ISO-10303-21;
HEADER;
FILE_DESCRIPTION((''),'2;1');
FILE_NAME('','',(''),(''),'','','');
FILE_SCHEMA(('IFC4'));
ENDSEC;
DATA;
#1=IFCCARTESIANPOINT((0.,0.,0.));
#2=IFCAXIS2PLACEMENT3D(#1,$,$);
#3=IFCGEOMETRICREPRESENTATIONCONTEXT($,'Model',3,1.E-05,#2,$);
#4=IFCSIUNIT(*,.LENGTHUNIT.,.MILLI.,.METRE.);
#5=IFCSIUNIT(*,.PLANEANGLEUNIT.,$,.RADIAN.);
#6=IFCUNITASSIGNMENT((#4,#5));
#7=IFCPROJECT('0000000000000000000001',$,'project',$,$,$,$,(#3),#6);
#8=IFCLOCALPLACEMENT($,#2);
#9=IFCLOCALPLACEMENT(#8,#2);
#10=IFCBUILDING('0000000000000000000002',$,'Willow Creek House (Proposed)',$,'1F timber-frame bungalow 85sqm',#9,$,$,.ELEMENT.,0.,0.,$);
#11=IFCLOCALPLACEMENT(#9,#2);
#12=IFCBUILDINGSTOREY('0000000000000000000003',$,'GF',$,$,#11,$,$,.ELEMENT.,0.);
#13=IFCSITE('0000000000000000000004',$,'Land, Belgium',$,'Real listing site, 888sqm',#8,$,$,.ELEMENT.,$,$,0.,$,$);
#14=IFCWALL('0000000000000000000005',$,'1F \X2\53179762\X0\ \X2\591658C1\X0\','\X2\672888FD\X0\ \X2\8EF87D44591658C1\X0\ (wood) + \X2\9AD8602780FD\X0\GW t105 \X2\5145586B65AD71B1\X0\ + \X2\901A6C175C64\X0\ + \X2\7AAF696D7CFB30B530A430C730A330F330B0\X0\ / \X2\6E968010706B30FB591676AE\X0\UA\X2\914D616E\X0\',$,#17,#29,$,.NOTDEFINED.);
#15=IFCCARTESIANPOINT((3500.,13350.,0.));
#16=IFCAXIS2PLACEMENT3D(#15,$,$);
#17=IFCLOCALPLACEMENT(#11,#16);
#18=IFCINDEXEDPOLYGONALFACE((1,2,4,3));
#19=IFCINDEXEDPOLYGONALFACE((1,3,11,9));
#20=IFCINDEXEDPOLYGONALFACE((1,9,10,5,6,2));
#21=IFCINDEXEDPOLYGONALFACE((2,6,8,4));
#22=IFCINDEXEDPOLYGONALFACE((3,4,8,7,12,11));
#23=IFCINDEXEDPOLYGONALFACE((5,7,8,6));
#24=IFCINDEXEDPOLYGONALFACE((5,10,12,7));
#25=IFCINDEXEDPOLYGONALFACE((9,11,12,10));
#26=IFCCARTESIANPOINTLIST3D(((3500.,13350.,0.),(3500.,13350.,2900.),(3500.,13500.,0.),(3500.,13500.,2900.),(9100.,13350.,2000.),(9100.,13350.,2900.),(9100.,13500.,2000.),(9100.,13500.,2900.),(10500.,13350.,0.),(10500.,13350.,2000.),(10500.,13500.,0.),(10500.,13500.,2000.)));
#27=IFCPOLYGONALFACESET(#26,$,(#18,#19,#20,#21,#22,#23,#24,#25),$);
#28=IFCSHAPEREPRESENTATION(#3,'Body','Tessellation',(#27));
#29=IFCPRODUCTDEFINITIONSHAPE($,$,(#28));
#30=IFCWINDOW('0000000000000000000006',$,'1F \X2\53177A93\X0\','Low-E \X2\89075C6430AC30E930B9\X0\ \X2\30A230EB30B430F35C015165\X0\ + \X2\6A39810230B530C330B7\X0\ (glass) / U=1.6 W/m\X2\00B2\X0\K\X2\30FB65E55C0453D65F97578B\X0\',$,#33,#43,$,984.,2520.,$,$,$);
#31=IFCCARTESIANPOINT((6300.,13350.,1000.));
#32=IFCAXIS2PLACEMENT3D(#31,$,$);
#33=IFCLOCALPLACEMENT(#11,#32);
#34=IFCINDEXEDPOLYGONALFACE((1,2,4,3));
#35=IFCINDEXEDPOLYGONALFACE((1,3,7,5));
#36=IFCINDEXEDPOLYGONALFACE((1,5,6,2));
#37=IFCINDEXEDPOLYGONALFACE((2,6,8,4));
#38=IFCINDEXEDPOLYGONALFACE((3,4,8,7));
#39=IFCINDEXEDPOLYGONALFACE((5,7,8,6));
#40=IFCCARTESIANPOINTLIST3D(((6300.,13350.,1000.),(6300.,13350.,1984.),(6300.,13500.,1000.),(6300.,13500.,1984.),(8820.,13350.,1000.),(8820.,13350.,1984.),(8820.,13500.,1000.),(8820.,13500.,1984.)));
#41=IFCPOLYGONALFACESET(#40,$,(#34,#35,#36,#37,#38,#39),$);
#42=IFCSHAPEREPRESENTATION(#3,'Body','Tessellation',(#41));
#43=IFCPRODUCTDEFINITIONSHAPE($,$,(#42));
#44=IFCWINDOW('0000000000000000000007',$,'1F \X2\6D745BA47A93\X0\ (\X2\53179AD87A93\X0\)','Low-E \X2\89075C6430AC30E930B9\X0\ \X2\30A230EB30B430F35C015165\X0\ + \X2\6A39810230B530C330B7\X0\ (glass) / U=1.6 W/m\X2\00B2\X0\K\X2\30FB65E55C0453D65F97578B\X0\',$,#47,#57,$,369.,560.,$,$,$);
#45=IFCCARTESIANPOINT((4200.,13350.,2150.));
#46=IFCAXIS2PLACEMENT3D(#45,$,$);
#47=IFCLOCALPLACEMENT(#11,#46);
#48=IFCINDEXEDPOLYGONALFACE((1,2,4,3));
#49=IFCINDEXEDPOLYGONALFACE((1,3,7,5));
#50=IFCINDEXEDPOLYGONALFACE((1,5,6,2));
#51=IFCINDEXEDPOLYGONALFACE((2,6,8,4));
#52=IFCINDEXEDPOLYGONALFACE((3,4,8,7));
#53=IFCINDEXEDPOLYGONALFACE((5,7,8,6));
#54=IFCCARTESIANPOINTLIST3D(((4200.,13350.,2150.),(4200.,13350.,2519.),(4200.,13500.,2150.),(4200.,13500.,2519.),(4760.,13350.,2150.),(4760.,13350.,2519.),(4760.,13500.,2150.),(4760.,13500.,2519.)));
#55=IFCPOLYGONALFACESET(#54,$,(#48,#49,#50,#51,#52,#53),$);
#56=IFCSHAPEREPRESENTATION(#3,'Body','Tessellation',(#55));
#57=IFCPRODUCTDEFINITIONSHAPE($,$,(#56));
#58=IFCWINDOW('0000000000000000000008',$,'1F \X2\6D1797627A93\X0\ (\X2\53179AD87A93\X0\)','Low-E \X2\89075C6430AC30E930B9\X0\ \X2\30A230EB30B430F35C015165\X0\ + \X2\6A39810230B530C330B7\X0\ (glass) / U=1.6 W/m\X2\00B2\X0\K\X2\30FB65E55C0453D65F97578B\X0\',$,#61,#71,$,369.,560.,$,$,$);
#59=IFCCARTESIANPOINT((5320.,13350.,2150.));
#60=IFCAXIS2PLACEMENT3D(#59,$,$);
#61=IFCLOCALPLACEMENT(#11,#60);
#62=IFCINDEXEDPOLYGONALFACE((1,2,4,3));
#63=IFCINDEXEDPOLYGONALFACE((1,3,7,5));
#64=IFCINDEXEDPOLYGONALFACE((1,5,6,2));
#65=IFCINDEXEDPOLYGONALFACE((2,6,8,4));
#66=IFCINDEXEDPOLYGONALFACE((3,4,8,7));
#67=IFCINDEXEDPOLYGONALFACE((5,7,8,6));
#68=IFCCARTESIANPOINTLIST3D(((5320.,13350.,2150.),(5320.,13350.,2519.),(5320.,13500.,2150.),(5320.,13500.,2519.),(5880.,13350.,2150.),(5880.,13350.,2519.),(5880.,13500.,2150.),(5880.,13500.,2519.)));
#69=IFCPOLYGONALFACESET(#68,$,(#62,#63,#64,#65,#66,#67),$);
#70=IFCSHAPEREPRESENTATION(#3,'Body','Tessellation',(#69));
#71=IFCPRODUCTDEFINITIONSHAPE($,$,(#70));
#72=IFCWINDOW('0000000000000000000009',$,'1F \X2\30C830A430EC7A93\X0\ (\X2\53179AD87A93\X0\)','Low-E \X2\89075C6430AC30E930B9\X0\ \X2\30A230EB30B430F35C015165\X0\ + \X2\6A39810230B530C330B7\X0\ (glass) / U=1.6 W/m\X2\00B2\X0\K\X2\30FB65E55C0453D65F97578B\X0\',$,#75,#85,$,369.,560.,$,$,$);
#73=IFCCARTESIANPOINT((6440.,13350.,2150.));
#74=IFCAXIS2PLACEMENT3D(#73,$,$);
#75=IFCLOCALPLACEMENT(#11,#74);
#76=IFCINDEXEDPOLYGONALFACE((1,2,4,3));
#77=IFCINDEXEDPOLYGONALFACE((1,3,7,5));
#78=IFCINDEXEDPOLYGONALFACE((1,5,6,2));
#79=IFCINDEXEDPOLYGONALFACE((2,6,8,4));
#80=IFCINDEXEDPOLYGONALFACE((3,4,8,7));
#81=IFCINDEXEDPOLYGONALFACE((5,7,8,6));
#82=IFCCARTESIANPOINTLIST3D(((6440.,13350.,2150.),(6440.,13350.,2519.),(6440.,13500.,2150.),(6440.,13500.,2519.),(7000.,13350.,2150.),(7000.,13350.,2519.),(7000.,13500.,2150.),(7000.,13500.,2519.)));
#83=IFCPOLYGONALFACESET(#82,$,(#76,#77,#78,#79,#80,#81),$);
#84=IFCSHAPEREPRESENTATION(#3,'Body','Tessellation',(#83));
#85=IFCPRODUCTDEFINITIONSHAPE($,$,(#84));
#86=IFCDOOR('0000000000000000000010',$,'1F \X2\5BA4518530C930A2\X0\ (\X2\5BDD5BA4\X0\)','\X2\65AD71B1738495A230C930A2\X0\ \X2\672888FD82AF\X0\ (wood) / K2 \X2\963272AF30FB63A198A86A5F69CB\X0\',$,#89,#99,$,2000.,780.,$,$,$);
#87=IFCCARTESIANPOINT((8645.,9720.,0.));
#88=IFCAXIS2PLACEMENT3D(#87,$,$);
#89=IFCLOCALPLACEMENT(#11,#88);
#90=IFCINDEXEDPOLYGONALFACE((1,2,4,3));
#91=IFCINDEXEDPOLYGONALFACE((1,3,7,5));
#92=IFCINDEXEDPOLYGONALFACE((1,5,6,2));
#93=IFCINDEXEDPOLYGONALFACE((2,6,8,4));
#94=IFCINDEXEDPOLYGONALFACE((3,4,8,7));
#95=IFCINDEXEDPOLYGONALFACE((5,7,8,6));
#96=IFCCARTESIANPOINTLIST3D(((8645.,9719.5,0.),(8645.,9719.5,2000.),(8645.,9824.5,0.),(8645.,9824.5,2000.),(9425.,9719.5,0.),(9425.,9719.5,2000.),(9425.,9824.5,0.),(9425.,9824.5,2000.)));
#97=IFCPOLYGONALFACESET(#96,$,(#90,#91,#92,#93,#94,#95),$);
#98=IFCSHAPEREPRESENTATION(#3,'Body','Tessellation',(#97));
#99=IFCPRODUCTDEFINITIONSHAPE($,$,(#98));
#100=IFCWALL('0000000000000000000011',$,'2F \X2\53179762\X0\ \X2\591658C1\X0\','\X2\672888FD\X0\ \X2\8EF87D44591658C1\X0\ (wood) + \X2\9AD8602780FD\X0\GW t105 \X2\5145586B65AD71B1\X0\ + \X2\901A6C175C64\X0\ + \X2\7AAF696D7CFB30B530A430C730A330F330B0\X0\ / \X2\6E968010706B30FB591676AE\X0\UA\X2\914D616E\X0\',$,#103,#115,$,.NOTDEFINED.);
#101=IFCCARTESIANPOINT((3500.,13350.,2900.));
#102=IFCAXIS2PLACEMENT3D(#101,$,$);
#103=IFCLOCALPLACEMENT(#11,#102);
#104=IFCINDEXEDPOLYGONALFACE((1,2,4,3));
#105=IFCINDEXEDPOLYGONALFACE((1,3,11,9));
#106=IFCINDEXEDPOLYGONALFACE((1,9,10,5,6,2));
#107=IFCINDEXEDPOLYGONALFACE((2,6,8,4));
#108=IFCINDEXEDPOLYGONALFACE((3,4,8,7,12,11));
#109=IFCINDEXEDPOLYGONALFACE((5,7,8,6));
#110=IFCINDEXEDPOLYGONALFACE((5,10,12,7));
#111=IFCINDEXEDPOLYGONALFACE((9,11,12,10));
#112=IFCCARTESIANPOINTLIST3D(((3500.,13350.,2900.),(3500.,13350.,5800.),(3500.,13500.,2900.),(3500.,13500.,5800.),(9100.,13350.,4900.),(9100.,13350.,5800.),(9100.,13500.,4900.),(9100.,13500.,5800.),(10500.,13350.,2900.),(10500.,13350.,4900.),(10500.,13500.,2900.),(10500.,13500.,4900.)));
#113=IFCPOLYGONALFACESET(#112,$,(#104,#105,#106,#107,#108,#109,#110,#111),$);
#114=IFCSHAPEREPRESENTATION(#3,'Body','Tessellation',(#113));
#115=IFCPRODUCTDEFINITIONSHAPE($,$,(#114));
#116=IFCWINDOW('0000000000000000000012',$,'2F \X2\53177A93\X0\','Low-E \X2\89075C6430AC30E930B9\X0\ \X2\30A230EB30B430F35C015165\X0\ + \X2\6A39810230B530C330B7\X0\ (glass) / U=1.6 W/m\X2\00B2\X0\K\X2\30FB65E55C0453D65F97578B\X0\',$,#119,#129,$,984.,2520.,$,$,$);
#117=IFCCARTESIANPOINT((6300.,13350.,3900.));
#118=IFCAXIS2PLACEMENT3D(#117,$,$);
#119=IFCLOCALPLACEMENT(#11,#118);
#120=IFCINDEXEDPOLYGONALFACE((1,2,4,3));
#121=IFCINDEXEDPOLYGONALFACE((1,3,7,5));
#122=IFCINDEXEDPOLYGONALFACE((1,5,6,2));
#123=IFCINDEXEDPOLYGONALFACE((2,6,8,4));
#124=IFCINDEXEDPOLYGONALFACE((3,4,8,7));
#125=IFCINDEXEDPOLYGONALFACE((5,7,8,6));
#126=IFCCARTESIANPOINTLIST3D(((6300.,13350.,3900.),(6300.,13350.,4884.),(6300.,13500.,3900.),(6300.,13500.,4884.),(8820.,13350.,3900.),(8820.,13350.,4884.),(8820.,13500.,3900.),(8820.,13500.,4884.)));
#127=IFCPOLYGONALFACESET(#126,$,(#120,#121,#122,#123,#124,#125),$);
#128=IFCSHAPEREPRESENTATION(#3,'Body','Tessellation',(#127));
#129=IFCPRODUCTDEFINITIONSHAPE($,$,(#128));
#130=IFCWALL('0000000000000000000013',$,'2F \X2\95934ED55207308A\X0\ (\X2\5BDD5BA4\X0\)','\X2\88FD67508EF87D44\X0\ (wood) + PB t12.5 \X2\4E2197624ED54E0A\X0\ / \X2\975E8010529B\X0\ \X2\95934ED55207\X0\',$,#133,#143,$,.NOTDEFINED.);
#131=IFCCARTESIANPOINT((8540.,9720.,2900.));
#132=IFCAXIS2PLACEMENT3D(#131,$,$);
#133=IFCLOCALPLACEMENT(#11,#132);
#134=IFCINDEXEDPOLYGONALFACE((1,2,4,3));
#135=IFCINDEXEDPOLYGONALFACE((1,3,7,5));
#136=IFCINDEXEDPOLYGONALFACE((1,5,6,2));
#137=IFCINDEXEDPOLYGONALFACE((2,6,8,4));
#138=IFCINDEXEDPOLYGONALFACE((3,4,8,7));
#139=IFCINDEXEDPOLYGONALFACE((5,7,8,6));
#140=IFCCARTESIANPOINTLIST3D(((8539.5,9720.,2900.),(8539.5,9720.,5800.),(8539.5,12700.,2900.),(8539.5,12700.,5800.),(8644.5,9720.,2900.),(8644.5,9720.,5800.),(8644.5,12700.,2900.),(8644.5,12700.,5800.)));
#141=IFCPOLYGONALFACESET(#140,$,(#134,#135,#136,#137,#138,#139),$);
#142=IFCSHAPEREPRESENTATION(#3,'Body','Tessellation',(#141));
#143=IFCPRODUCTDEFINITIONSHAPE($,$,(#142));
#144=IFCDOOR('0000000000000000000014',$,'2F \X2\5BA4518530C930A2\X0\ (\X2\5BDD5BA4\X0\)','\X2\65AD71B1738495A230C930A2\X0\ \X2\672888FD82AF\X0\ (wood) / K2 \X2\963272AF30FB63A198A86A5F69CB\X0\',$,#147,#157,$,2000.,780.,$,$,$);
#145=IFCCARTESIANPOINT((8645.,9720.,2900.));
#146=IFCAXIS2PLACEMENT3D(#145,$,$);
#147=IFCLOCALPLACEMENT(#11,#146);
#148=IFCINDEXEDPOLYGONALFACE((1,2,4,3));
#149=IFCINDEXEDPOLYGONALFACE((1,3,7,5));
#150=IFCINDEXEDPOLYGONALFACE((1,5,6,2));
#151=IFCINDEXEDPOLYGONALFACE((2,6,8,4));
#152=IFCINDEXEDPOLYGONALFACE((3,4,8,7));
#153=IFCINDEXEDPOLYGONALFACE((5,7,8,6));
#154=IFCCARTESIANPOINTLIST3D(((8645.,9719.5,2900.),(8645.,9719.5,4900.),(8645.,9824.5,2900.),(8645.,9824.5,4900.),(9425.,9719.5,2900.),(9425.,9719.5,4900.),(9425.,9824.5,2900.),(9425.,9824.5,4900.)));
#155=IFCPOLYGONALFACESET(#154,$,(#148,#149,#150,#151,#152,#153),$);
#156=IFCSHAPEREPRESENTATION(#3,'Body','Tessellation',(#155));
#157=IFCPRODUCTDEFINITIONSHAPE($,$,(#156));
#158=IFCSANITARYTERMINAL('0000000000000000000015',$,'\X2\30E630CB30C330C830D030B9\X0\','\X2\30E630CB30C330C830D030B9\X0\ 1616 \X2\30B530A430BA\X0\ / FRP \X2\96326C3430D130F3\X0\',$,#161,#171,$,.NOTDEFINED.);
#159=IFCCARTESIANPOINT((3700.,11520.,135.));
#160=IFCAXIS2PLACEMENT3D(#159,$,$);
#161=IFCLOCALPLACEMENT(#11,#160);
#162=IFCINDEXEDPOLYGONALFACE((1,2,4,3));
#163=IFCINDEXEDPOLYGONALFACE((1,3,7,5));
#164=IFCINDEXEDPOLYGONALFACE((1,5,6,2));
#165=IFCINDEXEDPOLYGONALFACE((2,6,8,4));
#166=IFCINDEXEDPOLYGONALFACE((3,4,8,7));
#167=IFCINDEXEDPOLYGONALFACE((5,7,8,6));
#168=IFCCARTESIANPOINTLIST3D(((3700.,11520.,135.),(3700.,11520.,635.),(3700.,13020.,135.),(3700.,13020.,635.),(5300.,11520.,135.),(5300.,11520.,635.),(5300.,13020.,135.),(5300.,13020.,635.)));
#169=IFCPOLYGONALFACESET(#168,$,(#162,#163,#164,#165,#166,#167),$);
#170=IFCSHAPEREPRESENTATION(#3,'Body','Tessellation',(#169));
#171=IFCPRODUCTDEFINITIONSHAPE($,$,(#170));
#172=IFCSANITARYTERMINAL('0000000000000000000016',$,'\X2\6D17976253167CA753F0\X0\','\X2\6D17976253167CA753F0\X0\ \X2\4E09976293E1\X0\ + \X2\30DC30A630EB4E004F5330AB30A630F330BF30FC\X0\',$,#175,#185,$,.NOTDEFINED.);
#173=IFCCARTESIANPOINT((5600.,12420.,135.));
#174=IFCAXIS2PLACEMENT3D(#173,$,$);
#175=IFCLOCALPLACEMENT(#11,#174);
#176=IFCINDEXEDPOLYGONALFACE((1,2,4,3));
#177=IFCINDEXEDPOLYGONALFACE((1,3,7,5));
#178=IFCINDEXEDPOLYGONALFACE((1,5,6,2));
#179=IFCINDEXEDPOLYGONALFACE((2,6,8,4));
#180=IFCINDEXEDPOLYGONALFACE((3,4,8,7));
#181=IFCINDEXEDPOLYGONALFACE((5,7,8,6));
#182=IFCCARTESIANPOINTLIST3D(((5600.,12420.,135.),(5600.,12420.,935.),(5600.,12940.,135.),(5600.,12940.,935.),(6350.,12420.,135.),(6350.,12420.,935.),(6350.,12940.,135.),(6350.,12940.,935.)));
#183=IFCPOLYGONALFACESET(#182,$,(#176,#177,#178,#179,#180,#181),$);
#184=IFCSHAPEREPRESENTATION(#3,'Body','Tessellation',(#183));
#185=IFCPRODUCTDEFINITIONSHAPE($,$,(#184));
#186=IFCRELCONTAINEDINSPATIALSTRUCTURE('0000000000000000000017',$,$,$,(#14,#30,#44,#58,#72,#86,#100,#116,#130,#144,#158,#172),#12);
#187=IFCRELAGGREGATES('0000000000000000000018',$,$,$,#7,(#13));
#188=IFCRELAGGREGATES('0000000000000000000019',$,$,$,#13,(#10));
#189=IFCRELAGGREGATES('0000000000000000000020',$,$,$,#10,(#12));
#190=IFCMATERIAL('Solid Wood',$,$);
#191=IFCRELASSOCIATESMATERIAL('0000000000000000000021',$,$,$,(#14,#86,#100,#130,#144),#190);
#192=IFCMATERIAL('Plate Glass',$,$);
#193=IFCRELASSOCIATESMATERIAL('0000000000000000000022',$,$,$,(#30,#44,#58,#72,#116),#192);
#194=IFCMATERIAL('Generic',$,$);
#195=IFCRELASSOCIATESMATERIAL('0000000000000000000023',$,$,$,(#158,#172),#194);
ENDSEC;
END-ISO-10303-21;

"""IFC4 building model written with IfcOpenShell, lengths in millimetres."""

from ifc_helpers import new_model, si_unit, frame, frame_2d, origin, place, context, project, spatial, rectangle, extrude, material, element, fill, save


model = new_model("IFC4")

# Units and contexts
model_context = context("Model", 3, precision=1e-05, world=origin())
ifc_project = project(units=[si_unit("LENGTHUNIT", "METRE", prefix="MILLI"), si_unit("PLANEANGLEUNIT", "RADIAN")], contexts=[model_context])

# Site, building, storey
site_placement = place(None, origin())
site = spatial("IfcSite", under=ifc_project, at=site_placement, Name="Land, Belgium", ObjectType="Real listing site, 888sqm", CompositionType="ELEMENT", RefElevation=0.0)
building_placement = place(site_placement, origin())
building = spatial("IfcBuilding", under=site, at=building_placement, Name="Willow Creek House (Proposed)", ObjectType="1F timber-frame bungalow 85sqm", CompositionType="ELEMENT", ElevationOfRefHeight=0.0, ElevationOfTerrain=0.0)
storey_placement = place(building_placement, origin())
storey = spatial("IfcBuildingStorey", under=building, at=storey_placement, Name="GF", CompositionType="ELEMENT", Elevation=0.0)

# Wall, openings, windows
ifc_material_1 = material(Name="Solid Wood")
wall_1_placement = place(storey_placement, frame((3500.0, 13350.0, 0.0)))
wall_1 = element("IfcWall", 1, at=wall_1_placement, inside=storey, material=ifc_material_1, Name="1F 北面 外壁", Description="木製 軸組外壁 (wood) + 高性能GW t105 充填断熱 + 通気層 + 窯業系サイディング / 準耐火・外皮UA配慮", PredefinedType="NOTDEFINED", context=model_context, shape_type="SweptSolid", body=[
    extrude(rectangle(XDim=7000.0, YDim=150.0, at=frame_2d((3500.0, 75.0))), frame((3500.0, 13350.0, 0.0)), (0.0, 0.0, 1.0), 2900.0),
])
opening_1_placement = place(storey_placement, frame((6300.0, 13350.0, 1000.0)))
opening_1 = element("IfcOpeningElement", 2, at=opening_1_placement, cuts=wall_1, PredefinedType="NOTDEFINED", context=model_context, shape_type="SweptSolid", body=[
    extrude(rectangle(XDim=2520.0, YDim=150.0, at=frame_2d((1260.0, 75.0))), frame((6300.0, 13350.0, 1000.0)), (0.0, 0.0, 1.0), 984.0),
])
opening_2_placement = place(storey_placement, frame((4200.0, 13350.0, 2150.0)))
opening_2 = element("IfcOpeningElement", 3, at=opening_2_placement, cuts=wall_1, PredefinedType="NOTDEFINED", context=model_context, shape_type="SweptSolid", body=[
    extrude(rectangle(XDim=560.0, YDim=150.0, at=frame_2d((280.0, 75.0))), frame((4200.0, 13350.0, 2150.0)), (0.0, 0.0, 1.0), 369.0),
])
opening_3_placement = place(storey_placement, frame((5320.0, 13350.0, 2150.0)))
opening_3 = element("IfcOpeningElement", 4, at=opening_3_placement, cuts=wall_1, PredefinedType="NOTDEFINED", context=model_context, shape_type="SweptSolid", body=[
    extrude(rectangle(XDim=560.0, YDim=150.0, at=frame_2d((280.0, 75.0))), frame((5320.0, 13350.0, 2150.0)), (0.0, 0.0, 1.0), 369.0),
])
opening_4_placement = place(storey_placement, frame((6440.0, 13350.0, 2150.0)))
opening_4 = element("IfcOpeningElement", 5, at=opening_4_placement, cuts=wall_1, PredefinedType="NOTDEFINED", context=model_context, shape_type="SweptSolid", body=[
    extrude(rectangle(XDim=560.0, YDim=150.0, at=frame_2d((280.0, 75.0))), frame((6440.0, 13350.0, 2150.0)), (0.0, 0.0, 1.0), 369.0),
])
ifc_material_2 = material(Name="Plate Glass")
window_1_placement = place(storey_placement, frame((6300.0, 13350.0, 1000.0)))
window_1 = element("IfcWindow", 6, at=window_1_placement, inside=storey, material=ifc_material_2, Name="1F 北窓", Description="Low-E 複層ガラス アルゴン封入 + 樹脂サッシ (glass) / U=1.6 W/m²K・日射取得型", OverallHeight=984.0, OverallWidth=2520.0, context=model_context, shape_type="SweptSolid", body=[
    extrude(rectangle(XDim=2520.0, YDim=150.0, at=frame_2d((1260.0, 75.0))), frame((6300.0, 13350.0, 1000.0)), (0.0, 0.0, 1.0), 984.0),
])
fill(opening_1, window_1)
window_2_placement = place(storey_placement, frame((4200.0, 13350.0, 2150.0)))
window_2 = element("IfcWindow", 7, at=window_2_placement, inside=storey, material=ifc_material_2, Name="1F 浴室窓 (北高窓)", Description="Low-E 複層ガラス アルゴン封入 + 樹脂サッシ (glass) / U=1.6 W/m²K・日射取得型", OverallHeight=369.0, OverallWidth=560.0, context=model_context, shape_type="SweptSolid", body=[
    extrude(rectangle(XDim=560.0, YDim=150.0, at=frame_2d((280.0, 75.0))), frame((4200.0, 13350.0, 2150.0)), (0.0, 0.0, 1.0), 369.0),
])
fill(opening_2, window_2)
window_3_placement = place(storey_placement, frame((5320.0, 13350.0, 2150.0)))
window_3 = element("IfcWindow", 8, at=window_3_placement, inside=storey, material=ifc_material_2, Name="1F 洗面窓 (北高窓)", Description="Low-E 複層ガラス アルゴン封入 + 樹脂サッシ (glass) / U=1.6 W/m²K・日射取得型", OverallHeight=369.0, OverallWidth=560.0, context=model_context, shape_type="SweptSolid", body=[
    extrude(rectangle(XDim=560.0, YDim=150.0, at=frame_2d((280.0, 75.0))), frame((5320.0, 13350.0, 2150.0)), (0.0, 0.0, 1.0), 369.0),
])
fill(opening_3, window_3)
window_4_placement = place(storey_placement, frame((6440.0, 13350.0, 2150.0)))
window_4 = element("IfcWindow", 9, at=window_4_placement, inside=storey, material=ifc_material_2, Name="1F トイレ窓 (北高窓)", Description="Low-E 複層ガラス アルゴン封入 + 樹脂サッシ (glass) / U=1.6 W/m²K・日射取得型", OverallHeight=369.0, OverallWidth=560.0, context=model_context, shape_type="SweptSolid", body=[
    extrude(rectangle(XDim=560.0, YDim=150.0, at=frame_2d((280.0, 75.0))), frame((6440.0, 13350.0, 2150.0)), (0.0, 0.0, 1.0), 369.0),
])
fill(opening_4, window_4)

# Door
door_1_placement = place(storey_placement, frame((8645.0, 9720.0, 0.0)))
element("IfcDoor", 10, at=door_1_placement, inside=storey, material=ifc_material_1, Name="1F 室内ドア (寝室)", Description="断熱玄関ドア 木製芯 (wood) / K2 防犯・採風機構", OverallHeight=2000.0, OverallWidth=780.0, context=model_context, shape_type="SweptSolid", body=[
    extrude(rectangle(XDim=780.0, YDim=105.0, at=frame_2d((390.0, 52.0))), frame((8645.0, 9720.0, 0.0)), (0.0, 0.0, 1.0), 2000.0),
])

# Wall, opening, window
wall_2_placement = place(storey_placement, frame((3500.0, 13350.0, 2900.0)))
wall_2 = element("IfcWall", 11, at=wall_2_placement, inside=storey, material=ifc_material_1, Name="2F 北面 外壁", Description="木製 軸組外壁 (wood) + 高性能GW t105 充填断熱 + 通気層 + 窯業系サイディング / 準耐火・外皮UA配慮", PredefinedType="NOTDEFINED", context=model_context, shape_type="SweptSolid", body=[
    extrude(rectangle(XDim=7000.0, YDim=150.0, at=frame_2d((3500.0, 75.0))), frame((3500.0, 13350.0, 2900.0)), (0.0, 0.0, 1.0), 2900.0),
])
opening_5_placement = place(storey_placement, frame((6300.0, 13350.0, 3900.0)))
opening_5 = element("IfcOpeningElement", 12, at=opening_5_placement, cuts=wall_2, PredefinedType="NOTDEFINED", context=model_context, shape_type="SweptSolid", body=[
    extrude(rectangle(XDim=2520.0, YDim=150.0, at=frame_2d((1260.0, 75.0))), frame((6300.0, 13350.0, 3900.0)), (0.0, 0.0, 1.0), 984.0),
])
window_5_placement = place(storey_placement, frame((6300.0, 13350.0, 3900.0)))
window_5 = element("IfcWindow", 13, at=window_5_placement, inside=storey, material=ifc_material_2, Name="2F 北窓", Description="Low-E 複層ガラス アルゴン封入 + 樹脂サッシ (glass) / U=1.6 W/m²K・日射取得型", OverallHeight=984.0, OverallWidth=2520.0, context=model_context, shape_type="SweptSolid", body=[
    extrude(rectangle(XDim=2520.0, YDim=150.0, at=frame_2d((1260.0, 75.0))), frame((6300.0, 13350.0, 3900.0)), (0.0, 0.0, 1.0), 984.0),
])
fill(opening_5, window_5)

# Wall
wall_3_placement = place(storey_placement, frame((8540.0, 9720.0, 2900.0)))
element("IfcWall", 14, at=wall_3_placement, inside=storey, material=ifc_material_1, Name="2F 間仕切り (寝室)", Description="製材軸組 (wood) + PB t12.5 両面仕上 / 非耐力 間仕切", PredefinedType="NOTDEFINED", context=model_context, shape_type="SweptSolid", body=[
    extrude(rectangle(XDim=105.0, YDim=2980.0, at=frame_2d((52.0, 1490.0))), frame((8540.0, 9720.0, 2900.0)), (0.0, 0.0, 1.0), 2900.0),
])

# Door
door_2_placement = place(storey_placement, frame((8645.0, 9720.0, 2900.0)))
element("IfcDoor", 15, at=door_2_placement, inside=storey, material=ifc_material_1, Name="2F 室内ドア (寝室)", Description="断熱玄関ドア 木製芯 (wood) / K2 防犯・採風機構", OverallHeight=2000.0, OverallWidth=780.0, context=model_context, shape_type="SweptSolid", body=[
    extrude(rectangle(XDim=780.0, YDim=105.0, at=frame_2d((390.0, 52.0))), frame((8645.0, 9720.0, 2900.0)), (0.0, 0.0, 1.0), 2000.0),
])

# Sanitary terminals
ifc_material_3 = material(Name="Generic")
sanitary_terminal_1_placement = place(storey_placement, frame((3700.0, 11520.0, 135.0)))
element("IfcSanitaryTerminal", 16, at=sanitary_terminal_1_placement, inside=storey, material=ifc_material_3, Name="ユニットバス", Description="ユニットバス 1616 サイズ / FRP 防水パン", PredefinedType="NOTDEFINED", context=model_context, shape_type="SweptSolid", body=[
    extrude(rectangle(XDim=1600.0, YDim=1500.0, at=frame_2d((800.0, 750.0))), frame((3700.0, 11520.0, 135.0)), (0.0, 0.0, 1.0), 500.0),
])
sanitary_terminal_2_placement = place(storey_placement, frame((5600.0, 12420.0, 135.0)))
element("IfcSanitaryTerminal", 17, at=sanitary_terminal_2_placement, inside=storey, material=ifc_material_3, Name="洗面化粧台", Description="洗面化粧台 三面鏡 + ボウル一体カウンター", PredefinedType="NOTDEFINED", context=model_context, shape_type="SweptSolid", body=[
    extrude(rectangle(XDim=750.0, YDim=520.0, at=frame_2d((375.0, 260.0))), frame((5600.0, 12420.0, 135.0)), (0.0, 0.0, 1.0), 800.0),
])

save(model, "model.ifc")
